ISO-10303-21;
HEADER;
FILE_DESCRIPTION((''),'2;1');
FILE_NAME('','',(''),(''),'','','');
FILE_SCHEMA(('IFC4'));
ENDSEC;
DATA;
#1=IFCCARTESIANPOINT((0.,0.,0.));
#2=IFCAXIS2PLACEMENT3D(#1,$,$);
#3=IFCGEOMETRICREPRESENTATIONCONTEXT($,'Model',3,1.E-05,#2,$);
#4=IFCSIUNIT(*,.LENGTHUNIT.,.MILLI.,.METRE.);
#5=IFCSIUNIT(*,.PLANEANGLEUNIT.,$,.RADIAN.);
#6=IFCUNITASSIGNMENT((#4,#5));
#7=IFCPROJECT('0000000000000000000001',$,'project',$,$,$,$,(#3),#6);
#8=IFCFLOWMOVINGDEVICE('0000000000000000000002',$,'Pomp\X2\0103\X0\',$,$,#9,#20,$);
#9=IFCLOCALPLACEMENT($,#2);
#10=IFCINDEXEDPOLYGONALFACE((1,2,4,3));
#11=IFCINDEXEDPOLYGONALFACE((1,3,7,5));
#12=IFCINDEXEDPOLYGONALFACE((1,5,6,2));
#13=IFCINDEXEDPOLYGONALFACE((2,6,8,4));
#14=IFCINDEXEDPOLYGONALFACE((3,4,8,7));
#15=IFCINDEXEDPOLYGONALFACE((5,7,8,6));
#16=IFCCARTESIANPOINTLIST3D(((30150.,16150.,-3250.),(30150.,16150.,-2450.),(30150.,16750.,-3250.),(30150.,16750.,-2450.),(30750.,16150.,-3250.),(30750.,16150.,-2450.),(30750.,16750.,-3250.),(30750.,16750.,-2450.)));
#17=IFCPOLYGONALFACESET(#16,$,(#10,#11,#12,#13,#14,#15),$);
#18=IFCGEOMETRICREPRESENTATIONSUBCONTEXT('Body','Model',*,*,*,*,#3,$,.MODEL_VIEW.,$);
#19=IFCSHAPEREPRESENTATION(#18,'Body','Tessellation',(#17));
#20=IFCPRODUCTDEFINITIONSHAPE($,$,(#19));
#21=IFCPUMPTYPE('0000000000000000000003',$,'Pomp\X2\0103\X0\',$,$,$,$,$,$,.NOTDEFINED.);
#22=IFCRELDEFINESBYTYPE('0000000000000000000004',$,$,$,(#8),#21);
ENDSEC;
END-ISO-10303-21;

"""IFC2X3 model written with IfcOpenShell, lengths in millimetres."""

from ifc_helpers import new_model, si_unit, frame, frame_2d, origin, place, context, subcontext, project, rectangle, extrude, type_object, element, save


model = new_model("IFC2X3")

# Units and contexts
model_context = context("Model", 3, precision=1e-05, world=origin())
body_context = subcontext(model_context, "Body", "Model", "MODEL_VIEW")
ifc_project = project(units=[si_unit("LENGTHUNIT", "METRE", prefix="MILLI"), si_unit("PLANEANGLEUNIT", "RADIAN")], contexts=[model_context])

# Flow moving device
pump_type = type_object("IfcPumpType", Name="Pompă", PredefinedType="NOTDEFINED")
flow_moving_device_placement = place(None, frame((30150.0, 16150.0, -3250.0)))
element("IfcFlowMovingDevice", 1, at=flow_moving_device_placement, type_object=pump_type, Name="Pompă", context=body_context, shape_type="SweptSolid", body=[
    extrude(rectangle(XDim=600.0, YDim=600.0, at=frame_2d((300.0, 300.0))), origin(), (0.0, 0.0, 1.0), 800.0),
])

save(model, "model.ifc")
